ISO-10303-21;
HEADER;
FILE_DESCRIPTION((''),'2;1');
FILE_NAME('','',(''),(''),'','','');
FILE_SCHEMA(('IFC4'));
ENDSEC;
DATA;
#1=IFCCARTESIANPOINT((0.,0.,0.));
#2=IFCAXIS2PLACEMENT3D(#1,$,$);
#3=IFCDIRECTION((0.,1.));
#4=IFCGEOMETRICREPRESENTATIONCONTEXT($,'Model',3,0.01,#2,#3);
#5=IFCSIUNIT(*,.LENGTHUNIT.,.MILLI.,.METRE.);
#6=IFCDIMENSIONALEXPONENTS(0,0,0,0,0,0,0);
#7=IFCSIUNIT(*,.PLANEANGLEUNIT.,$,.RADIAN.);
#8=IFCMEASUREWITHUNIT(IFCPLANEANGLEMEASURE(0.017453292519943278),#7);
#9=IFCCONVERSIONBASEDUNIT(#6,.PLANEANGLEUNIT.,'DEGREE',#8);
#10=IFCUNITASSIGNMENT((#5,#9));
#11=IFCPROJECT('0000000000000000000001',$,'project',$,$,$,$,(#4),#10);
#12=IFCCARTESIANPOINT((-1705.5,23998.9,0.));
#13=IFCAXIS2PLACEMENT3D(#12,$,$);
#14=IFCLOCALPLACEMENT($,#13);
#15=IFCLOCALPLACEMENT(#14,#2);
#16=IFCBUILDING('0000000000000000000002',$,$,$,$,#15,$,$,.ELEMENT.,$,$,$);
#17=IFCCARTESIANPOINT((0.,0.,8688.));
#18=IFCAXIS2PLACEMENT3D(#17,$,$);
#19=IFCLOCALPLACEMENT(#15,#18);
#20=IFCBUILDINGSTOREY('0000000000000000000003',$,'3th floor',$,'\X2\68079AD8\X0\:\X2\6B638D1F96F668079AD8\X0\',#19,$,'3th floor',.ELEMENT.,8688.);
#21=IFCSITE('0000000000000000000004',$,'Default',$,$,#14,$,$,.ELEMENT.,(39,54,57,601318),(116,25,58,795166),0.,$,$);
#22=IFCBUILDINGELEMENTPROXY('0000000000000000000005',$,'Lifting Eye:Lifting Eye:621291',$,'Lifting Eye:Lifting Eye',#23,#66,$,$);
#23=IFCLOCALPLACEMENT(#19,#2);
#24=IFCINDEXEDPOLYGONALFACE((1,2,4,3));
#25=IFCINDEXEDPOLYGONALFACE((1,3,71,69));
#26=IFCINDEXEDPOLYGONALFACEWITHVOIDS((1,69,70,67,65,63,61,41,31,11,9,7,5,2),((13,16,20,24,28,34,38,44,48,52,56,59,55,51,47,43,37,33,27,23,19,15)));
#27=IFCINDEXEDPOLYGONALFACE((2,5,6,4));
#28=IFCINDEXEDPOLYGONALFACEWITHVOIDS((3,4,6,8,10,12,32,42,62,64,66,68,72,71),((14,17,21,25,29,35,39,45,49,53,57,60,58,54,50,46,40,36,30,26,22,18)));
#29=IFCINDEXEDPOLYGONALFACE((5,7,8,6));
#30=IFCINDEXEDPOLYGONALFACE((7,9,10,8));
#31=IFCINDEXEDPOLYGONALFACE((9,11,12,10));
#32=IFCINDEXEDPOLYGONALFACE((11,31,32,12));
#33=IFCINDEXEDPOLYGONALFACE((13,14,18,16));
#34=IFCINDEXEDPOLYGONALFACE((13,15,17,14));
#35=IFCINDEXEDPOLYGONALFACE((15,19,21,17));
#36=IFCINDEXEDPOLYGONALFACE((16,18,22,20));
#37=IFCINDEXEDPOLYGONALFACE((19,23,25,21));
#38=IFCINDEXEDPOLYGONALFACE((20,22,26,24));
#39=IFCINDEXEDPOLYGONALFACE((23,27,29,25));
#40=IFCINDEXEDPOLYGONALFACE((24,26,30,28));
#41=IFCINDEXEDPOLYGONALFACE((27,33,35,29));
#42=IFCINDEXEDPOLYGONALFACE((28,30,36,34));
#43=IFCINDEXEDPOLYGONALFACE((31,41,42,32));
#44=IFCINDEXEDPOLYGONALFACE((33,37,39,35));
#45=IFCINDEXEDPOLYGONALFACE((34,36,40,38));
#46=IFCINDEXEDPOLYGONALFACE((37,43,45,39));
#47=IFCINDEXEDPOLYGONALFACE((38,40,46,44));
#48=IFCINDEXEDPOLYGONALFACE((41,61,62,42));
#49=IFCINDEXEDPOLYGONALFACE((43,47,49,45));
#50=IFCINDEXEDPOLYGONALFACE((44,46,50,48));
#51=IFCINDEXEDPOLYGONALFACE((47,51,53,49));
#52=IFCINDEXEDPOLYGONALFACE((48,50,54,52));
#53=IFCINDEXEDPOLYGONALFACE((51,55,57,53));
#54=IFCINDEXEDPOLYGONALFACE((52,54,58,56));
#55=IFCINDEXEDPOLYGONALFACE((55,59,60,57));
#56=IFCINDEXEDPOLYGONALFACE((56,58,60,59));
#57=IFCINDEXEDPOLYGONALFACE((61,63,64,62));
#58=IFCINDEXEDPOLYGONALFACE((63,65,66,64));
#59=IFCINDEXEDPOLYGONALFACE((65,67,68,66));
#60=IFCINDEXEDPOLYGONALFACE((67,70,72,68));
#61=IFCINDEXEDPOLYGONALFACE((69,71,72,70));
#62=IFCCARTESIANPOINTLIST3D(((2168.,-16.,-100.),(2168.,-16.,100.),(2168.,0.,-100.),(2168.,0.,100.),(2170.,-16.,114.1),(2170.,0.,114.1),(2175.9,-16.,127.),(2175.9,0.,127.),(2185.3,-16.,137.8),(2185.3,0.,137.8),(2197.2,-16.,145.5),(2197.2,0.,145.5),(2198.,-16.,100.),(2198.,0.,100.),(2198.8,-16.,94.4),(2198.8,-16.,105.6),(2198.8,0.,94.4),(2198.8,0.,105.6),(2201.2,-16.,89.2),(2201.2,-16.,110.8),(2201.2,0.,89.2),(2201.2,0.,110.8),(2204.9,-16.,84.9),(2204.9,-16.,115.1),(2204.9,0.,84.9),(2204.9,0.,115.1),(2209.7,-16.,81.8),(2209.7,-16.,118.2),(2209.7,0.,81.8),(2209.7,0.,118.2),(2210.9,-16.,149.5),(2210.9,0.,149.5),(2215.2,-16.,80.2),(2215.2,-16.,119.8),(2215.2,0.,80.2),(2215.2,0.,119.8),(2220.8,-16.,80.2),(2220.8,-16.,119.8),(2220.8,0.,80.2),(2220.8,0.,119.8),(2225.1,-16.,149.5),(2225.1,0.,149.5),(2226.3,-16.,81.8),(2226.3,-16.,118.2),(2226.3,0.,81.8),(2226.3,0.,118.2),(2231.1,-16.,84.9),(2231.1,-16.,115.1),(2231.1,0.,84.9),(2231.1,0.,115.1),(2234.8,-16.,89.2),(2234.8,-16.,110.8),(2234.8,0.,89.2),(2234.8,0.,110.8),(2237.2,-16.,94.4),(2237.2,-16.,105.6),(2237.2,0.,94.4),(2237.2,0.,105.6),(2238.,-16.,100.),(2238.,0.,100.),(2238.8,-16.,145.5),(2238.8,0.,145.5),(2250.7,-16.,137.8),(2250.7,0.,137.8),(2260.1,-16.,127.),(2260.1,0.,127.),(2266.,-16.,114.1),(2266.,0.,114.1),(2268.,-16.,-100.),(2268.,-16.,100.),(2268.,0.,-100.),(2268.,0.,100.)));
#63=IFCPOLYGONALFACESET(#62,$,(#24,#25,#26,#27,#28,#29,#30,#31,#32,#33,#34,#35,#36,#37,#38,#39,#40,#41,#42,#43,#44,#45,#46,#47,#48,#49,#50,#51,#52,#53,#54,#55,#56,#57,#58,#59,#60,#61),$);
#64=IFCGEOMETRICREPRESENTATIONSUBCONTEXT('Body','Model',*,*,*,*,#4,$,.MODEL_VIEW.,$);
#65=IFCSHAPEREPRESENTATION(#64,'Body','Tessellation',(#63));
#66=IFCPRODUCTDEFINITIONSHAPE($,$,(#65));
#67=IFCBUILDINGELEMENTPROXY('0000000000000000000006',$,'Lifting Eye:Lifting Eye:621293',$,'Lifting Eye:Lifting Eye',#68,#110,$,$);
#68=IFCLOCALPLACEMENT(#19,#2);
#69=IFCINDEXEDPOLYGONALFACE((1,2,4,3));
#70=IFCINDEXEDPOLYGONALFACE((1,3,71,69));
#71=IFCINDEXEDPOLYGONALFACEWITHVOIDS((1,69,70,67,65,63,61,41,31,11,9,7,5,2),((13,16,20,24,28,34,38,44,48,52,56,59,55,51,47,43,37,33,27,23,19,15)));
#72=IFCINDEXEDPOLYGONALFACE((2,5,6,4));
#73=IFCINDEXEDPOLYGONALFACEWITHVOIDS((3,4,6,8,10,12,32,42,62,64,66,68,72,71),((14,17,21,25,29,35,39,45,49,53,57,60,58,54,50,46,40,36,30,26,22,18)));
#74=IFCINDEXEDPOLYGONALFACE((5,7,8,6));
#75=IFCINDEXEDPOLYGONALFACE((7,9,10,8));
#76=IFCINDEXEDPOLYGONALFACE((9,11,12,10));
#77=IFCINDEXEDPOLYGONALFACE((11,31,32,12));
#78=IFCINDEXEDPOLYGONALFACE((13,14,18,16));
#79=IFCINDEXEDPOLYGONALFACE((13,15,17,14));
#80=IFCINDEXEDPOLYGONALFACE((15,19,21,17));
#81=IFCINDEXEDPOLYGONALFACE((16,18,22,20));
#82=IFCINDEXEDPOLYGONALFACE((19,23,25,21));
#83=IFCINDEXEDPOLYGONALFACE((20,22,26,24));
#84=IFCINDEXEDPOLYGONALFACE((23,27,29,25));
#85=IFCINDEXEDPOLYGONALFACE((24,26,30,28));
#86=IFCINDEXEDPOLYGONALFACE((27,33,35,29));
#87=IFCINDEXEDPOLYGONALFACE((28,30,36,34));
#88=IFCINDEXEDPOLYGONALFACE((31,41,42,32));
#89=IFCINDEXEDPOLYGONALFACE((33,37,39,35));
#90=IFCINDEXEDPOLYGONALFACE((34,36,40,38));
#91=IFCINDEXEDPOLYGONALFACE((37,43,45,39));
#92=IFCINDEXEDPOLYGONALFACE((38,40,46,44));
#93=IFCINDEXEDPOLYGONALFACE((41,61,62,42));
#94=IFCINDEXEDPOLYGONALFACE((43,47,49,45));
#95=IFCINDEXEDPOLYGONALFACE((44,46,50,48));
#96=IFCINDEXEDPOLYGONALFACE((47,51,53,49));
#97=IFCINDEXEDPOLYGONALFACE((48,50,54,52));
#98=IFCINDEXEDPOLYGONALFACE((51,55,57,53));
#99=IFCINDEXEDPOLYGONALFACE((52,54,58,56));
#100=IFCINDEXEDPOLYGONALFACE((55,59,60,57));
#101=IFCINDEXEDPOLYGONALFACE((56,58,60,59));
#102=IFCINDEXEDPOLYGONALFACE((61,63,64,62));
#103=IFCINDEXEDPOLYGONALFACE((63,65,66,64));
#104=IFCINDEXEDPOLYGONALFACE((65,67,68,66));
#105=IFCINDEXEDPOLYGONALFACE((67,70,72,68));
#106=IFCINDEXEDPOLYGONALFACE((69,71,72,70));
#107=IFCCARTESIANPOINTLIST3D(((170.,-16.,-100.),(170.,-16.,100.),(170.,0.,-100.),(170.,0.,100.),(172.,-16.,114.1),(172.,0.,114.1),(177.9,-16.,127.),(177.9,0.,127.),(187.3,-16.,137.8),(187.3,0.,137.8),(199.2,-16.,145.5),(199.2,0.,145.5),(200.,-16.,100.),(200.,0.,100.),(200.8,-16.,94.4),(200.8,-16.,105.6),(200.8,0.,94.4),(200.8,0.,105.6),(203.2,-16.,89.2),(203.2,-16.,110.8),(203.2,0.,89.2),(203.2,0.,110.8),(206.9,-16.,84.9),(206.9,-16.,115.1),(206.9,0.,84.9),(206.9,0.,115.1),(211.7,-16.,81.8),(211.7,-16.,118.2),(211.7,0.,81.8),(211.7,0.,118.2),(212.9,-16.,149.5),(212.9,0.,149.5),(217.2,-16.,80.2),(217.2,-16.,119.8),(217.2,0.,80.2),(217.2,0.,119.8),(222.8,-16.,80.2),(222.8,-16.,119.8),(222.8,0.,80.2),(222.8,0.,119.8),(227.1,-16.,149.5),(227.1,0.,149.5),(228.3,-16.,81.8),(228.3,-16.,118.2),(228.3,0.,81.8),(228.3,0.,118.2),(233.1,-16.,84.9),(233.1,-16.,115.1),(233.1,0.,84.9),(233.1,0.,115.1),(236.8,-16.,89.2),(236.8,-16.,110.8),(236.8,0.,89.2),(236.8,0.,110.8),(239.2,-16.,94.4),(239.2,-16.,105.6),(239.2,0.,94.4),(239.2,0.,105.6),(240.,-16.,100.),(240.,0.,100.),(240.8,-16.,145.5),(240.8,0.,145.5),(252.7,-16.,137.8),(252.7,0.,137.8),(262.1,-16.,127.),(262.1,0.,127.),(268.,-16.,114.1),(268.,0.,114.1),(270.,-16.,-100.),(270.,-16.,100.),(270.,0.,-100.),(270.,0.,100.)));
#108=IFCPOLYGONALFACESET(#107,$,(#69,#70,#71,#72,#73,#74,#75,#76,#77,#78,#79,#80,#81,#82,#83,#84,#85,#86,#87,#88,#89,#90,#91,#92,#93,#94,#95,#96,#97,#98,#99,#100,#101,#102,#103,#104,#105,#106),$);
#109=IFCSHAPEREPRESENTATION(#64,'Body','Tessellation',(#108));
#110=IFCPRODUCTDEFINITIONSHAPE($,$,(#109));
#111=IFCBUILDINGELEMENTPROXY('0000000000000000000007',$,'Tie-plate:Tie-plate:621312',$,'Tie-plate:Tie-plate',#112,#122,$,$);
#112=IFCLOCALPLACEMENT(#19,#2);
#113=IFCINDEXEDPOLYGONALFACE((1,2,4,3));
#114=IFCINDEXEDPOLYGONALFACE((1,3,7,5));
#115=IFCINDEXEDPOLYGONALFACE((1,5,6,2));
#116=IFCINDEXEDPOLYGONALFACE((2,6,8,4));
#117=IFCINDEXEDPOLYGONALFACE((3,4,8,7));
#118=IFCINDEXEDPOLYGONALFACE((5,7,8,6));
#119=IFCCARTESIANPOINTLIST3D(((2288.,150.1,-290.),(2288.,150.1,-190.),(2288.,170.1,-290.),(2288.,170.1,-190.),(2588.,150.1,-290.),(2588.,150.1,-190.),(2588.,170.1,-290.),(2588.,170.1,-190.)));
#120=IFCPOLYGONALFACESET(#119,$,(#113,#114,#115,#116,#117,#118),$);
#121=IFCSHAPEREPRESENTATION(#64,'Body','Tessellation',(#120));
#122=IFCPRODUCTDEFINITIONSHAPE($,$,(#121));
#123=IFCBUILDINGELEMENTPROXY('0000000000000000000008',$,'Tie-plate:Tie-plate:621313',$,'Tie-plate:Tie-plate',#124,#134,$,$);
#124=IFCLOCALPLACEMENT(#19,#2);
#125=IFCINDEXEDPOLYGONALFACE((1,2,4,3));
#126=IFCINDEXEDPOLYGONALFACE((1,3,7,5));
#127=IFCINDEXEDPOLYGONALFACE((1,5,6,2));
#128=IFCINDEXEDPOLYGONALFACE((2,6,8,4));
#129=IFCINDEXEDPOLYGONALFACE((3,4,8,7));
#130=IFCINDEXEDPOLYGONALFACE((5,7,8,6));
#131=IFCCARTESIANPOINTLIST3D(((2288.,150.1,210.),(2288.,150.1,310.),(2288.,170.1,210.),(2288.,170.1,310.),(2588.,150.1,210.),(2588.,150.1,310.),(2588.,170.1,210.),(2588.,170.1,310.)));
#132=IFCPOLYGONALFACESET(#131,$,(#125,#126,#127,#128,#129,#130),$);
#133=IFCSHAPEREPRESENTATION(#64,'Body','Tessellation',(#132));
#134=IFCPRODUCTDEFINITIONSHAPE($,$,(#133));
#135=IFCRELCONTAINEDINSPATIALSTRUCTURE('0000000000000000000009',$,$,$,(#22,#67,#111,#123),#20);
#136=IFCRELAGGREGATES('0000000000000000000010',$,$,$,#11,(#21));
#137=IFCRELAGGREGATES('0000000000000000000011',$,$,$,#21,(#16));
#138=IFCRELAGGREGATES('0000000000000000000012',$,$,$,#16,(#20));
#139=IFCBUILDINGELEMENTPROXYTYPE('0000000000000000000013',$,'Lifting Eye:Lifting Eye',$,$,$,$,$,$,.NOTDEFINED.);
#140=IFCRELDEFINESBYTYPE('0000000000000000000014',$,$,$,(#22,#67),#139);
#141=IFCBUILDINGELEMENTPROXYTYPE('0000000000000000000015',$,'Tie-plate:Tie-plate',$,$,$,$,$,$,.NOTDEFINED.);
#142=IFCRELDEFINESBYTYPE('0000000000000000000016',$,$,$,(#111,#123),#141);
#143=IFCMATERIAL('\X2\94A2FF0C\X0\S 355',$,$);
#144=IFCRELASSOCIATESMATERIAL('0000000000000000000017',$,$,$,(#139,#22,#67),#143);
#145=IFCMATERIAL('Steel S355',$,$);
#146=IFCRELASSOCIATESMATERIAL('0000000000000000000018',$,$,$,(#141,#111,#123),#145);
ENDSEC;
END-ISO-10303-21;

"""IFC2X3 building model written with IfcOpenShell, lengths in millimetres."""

from ifc_helpers import new_model, entity, si_unit, converted_unit, direction, frame, frame_2d, origin, place, context, subcontext, project, spatial, polyline, circle_curve, parameter, trimmed, segment, composite_curve, rectangle, outline, extrude, source, transform, mapped, material, type_object, type_shapes, element, save


model = new_model("IFC2X3")

# Units and contexts
model_context = context("Model", 3, precision=0.01, world=origin(), true_north=direction((0.0, 1.0)))
body_context = subcontext(model_context, "Body", "Model", "MODEL_VIEW")
ifc_project = project(units=[si_unit("LENGTHUNIT", "METRE", prefix="MILLI"), converted_unit("PLANEANGLEUNIT", "DEGREE", entity("IfcPlaneAngleMeasure", 0.017453292519943278), si_unit("PLANEANGLEUNIT", "RADIAN"), dimensions=[0, 0, 0, 0, 0, 0, 0])], contexts=[model_context])

# Site, building, storey
site_placement = place(None, frame((-1705.5, 23998.9, 0.0)))
site = spatial("IfcSite", under=ifc_project, at=site_placement, Name="Default", CompositionType="ELEMENT", RefLatitude=(39, 54, 57, 601318), RefLongitude=(116, 25, 58, 795166), RefElevation=0.0)
building_placement = place(site_placement, origin())
building = spatial("IfcBuilding", under=site, at=building_placement, CompositionType="ELEMENT")
storey_placement = place(building_placement, frame((0.0, 0.0, 8688.0)))
storey = spatial("IfcBuildingStorey", under=building, at=storey_placement, Name="3th floor", ObjectType="标高:正负零标高", LongName="3th floor", CompositionType="ELEMENT", Elevation=8688.0)

# Shared definitions
ifc_material_1 = material(Name="Steel S355")

# Building element proxies
ifc_material_2 = material(Name="钢，S 355")
building_element_proxy_type_1 = type_object("IfcBuildingElementProxyType", Name="Lifting Eye:Lifting Eye", PredefinedType="NOTDEFINED", material=ifc_material_2)
shared_shape_1 = source(origin(), body_context, "Body", "SweptSolid", [
    extrude(outline(composite_curve([segment(polyline([(-100.0, -50.0), (100.0, -50.0)]), True, "CONTINUOUS"), segment(polyline([(100.0, -50.0), (100.0, 50.0)]), True, "CONTINUOUS"), segment(polyline([(100.0, 50.0), (-100.0, 50.0)]), True, "CONTINUOUS"), segment(trimmed(circle_curve(frame_2d((-100.0, 0.0), x_axis=(0.0, -1.0)), 50.0), [parameter(180.0)], [parameter(0.0)], True, "PARAMETER"), True, "CONTINUOUS")], self_intersect=False), holes=[composite_curve([segment(trimmed(circle_curve(frame_2d((-100.0, 0.0), x_axis=(0.0, -1.0)), 20.0), [parameter(180.0)], [parameter(360.0)], True, "PARAMETER"), False, "CONTINUOUS"), segment(trimmed(circle_curve(frame_2d((-100.0, 0.0), x_axis=(0.0, -1.0)), 20.0), [parameter(0.0)], [parameter(180.0)], True, "PARAMETER"), False, "CONTINUOUS")], self_intersect=False)]), frame((0.0, 17.0, -17.0), z_axis=(0.0, 1.0, 0.0), x_axis=(0.0, 0.0, -1.0)), (0.0, 0.0, 1.0), 16.0),
])
type_shapes(building_element_proxy_type_1, [shared_shape_1])
for number, where, name in (
    (1, (2218.0, -33.0, 17.0), "Lifting Eye:Lifting Eye:621291"),
    (2, (220.0, -33.0, 17.0), "Lifting Eye:Lifting Eye:621293"),
):
    element("IfcBuildingElementProxy", number, at=place(storey_placement, frame(where)), inside=storey, type_object=building_element_proxy_type_1, material=ifc_material_2, Name=name, ObjectType="Lifting Eye:Lifting Eye", context=body_context, shape_type="MappedRepresentation", body=[
        mapped(shared_shape_1, transform((0.0, 0.0, 0.0), scale=1.0)),
    ])
building_element_proxy_type_2 = type_object("IfcBuildingElementProxyType", Name="Tie-plate:Tie-plate", PredefinedType="NOTDEFINED", material=ifc_material_1)
shared_shape_2 = source(origin(), body_context, "Body", "SweptSolid", [
    extrude(rectangle(XDim=20.0, YDim=300.0, at=frame_2d((0.0, 0.0), x_axis=(1.0, 0.0))), frame((150.0, 10.0, 0.0), z_axis=(0.0, 0.0, 1.0), x_axis=(0.0, 1.0, 0.0)), (0.0, 0.0, 1.0), 100.0),
])
type_shapes(building_element_proxy_type_2, [shared_shape_2])
for number, where, name in (
    (3, (2288.0, 150.1, -290.0), "Tie-plate:Tie-plate:621312"),
    (4, (2288.0, 150.1, 210.0), "Tie-plate:Tie-plate:621313"),
):
    element("IfcBuildingElementProxy", number, at=place(storey_placement, frame(where)), inside=storey, type_object=building_element_proxy_type_2, material=ifc_material_1, Name=name, ObjectType="Tie-plate:Tie-plate", context=body_context, shape_type="MappedRepresentation", body=[
        mapped(shared_shape_2, transform((0.0, 0.0, 0.0), scale=1.0)),
    ])

save(model, "model.ifc")
